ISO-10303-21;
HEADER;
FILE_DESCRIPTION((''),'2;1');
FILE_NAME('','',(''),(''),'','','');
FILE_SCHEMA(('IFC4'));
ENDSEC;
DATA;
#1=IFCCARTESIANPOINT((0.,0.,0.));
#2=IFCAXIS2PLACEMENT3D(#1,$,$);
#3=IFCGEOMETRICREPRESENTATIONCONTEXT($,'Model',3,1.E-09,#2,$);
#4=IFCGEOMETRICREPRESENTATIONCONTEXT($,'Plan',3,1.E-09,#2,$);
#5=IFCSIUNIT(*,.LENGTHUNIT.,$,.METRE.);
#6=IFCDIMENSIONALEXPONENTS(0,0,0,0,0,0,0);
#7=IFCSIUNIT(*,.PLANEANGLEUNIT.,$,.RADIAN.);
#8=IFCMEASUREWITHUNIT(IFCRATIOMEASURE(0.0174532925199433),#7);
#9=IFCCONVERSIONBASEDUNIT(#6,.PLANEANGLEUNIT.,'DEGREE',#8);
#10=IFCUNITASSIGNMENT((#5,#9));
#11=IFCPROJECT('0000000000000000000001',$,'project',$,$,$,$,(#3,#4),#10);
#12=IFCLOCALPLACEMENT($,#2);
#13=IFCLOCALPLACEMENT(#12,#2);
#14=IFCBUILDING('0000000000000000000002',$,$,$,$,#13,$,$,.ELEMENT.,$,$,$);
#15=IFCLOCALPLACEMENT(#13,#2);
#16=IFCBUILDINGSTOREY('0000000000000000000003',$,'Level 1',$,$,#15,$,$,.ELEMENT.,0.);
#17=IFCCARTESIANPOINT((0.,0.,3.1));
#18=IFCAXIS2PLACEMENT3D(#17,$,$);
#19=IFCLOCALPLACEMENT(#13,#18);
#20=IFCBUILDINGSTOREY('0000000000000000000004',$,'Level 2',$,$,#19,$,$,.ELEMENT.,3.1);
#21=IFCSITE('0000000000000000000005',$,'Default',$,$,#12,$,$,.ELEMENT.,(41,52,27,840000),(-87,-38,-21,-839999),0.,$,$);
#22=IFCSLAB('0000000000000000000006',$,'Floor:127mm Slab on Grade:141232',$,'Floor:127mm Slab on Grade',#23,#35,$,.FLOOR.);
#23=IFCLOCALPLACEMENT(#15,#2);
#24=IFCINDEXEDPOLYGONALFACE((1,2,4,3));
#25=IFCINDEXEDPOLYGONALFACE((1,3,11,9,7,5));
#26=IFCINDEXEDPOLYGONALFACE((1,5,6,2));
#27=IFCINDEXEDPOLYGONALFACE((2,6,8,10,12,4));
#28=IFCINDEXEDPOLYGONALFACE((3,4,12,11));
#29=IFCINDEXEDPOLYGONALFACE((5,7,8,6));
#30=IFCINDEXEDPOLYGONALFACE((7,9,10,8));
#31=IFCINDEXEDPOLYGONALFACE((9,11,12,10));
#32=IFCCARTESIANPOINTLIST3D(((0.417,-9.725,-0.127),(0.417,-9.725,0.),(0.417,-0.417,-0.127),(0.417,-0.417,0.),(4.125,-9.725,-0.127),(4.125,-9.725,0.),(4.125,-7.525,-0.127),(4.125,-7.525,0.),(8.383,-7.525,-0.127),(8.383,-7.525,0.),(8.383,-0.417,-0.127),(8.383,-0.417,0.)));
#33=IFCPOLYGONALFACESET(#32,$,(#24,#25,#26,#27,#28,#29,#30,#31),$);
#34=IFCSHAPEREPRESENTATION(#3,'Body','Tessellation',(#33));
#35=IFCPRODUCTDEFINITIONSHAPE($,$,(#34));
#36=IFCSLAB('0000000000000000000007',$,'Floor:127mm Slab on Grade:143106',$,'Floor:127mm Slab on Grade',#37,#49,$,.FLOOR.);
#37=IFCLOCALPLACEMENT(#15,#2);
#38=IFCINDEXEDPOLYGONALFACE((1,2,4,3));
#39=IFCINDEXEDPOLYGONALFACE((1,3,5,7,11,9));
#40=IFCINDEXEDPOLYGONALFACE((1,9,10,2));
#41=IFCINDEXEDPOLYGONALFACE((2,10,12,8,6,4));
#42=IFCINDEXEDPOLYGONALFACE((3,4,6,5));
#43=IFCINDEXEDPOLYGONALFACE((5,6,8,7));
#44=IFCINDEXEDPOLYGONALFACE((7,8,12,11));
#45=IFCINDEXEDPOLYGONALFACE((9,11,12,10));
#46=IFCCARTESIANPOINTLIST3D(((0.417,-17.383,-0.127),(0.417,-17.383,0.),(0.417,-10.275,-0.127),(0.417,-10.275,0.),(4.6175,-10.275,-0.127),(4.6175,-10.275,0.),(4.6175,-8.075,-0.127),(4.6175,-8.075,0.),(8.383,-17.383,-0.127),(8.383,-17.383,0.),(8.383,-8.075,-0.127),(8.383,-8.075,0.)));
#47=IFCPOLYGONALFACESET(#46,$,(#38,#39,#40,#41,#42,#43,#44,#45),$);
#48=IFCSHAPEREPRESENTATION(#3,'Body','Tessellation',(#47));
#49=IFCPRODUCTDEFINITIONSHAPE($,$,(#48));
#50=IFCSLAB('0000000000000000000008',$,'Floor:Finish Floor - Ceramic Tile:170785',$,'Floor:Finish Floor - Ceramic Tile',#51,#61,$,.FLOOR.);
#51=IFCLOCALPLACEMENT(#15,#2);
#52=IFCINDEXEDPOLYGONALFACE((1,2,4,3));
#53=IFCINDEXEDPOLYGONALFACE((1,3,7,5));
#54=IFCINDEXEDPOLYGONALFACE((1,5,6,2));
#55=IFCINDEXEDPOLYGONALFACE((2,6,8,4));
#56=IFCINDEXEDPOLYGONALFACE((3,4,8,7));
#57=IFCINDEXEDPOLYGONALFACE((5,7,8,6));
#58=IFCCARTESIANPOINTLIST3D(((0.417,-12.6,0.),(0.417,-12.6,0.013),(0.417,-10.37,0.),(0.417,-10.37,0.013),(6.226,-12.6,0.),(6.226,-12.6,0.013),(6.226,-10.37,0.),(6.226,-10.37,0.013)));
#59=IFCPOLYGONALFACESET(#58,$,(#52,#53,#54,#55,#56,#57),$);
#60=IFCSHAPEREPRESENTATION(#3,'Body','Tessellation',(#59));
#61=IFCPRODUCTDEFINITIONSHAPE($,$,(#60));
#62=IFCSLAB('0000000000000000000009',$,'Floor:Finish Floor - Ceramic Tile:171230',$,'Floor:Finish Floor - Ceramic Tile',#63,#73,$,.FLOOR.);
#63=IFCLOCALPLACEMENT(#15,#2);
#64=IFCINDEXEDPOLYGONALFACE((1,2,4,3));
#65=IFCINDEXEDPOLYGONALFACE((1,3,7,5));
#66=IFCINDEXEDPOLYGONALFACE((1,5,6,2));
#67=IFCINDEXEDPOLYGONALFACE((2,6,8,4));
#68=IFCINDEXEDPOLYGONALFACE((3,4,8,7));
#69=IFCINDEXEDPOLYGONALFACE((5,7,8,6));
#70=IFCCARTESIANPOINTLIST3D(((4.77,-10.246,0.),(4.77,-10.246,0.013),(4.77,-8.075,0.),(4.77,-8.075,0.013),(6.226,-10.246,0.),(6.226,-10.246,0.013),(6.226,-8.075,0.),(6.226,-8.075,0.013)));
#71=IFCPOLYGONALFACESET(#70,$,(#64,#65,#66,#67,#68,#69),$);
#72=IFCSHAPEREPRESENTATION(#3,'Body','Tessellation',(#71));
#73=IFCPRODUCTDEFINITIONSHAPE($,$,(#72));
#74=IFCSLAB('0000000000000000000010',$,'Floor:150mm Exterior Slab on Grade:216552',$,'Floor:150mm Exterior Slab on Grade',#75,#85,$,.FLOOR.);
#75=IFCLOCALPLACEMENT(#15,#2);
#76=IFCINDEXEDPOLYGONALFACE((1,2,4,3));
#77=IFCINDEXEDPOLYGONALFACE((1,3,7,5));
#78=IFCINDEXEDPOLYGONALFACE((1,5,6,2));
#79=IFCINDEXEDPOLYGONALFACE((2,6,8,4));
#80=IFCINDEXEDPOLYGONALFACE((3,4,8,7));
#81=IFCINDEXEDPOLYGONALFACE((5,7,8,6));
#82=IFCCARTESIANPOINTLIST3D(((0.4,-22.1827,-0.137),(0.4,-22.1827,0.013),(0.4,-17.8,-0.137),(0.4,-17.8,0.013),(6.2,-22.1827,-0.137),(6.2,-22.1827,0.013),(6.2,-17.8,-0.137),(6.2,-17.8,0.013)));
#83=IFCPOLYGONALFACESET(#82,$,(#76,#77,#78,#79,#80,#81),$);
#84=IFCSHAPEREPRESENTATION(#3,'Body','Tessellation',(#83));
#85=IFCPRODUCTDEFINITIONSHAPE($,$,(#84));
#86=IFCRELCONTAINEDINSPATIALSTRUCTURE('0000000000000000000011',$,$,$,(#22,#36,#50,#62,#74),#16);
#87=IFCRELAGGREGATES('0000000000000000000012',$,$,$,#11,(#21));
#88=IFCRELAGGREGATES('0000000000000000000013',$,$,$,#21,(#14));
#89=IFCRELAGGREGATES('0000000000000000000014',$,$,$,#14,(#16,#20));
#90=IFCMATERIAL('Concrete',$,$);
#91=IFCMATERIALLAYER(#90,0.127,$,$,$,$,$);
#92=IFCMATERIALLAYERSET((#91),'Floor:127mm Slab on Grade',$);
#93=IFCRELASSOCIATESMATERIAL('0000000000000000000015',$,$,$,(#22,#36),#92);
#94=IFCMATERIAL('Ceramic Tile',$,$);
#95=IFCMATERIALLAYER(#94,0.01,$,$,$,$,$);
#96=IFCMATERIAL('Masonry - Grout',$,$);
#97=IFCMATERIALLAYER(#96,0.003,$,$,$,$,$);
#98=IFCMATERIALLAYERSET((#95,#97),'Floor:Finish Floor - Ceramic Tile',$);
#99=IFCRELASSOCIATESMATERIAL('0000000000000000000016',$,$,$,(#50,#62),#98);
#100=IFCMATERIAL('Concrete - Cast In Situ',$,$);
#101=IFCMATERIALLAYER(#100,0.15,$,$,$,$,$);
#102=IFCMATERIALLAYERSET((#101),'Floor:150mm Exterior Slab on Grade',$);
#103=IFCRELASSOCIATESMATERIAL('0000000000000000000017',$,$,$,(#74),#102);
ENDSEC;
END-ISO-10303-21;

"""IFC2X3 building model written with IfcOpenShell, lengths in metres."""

from ifc_helpers import new_model, entity, si_unit, converted_unit, frame, frame_2d, origin, origin_2d_with_axis, place, context, project, spatial, polyline, rectangle, outline, extrude, material, layer, layer_set, layer_usage, element, save


model = new_model("IFC2X3")

# Units and contexts
model_context = context("Model", 3, precision=1e-09, world=origin())
plan_context = context("Plan", 3, precision=1e-09, world=origin())
ifc_project = project(units=[si_unit("LENGTHUNIT", "METRE"), converted_unit("PLANEANGLEUNIT", "DEGREE", entity("IfcRatioMeasure", 0.0174532925199433), si_unit("PLANEANGLEUNIT", "RADIAN"), dimensions=[0, 0, 0, 0, 0, 0, 0])], contexts=[model_context, plan_context])

# Site, building, storey
site_placement = place(None, origin())
site = spatial("IfcSite", under=ifc_project, at=site_placement, Name="Default", CompositionType="ELEMENT", RefLatitude=(41, 52, 27, 840000), RefLongitude=(-87, -38, -21, -839999), RefElevation=0.0)
building_placement = place(site_placement, origin())
building = spatial("IfcBuilding", under=site, at=building_placement, CompositionType="ELEMENT")
storey_1_placement = place(building_placement, origin())
storey_1 = spatial("IfcBuildingStorey", under=building, at=storey_1_placement, Name="Level 1", CompositionType="ELEMENT", Elevation=0.0)

# Slabs
ifc_material_1 = material(Name="Concrete")
ifc_layer_1 = layer(ifc_material_1, 0.127)
ifc_layer_set_1 = layer_set([ifc_layer_1], Name="Floor:127mm Slab on Grade")
ifc_layer_usage_1 = layer_usage(ifc_layer_set_1, "AXIS3", "POSITIVE", 0.0)
slab_1_placement = place(storey_1_placement, frame((0.417, -9.725, -0.127)))
element("IfcSlab", 1, at=slab_1_placement, inside=storey_1, material=ifc_layer_usage_1, Name="Floor:127mm Slab on Grade:141232", ObjectType="Floor:127mm Slab on Grade", PredefinedType="FLOOR", context=model_context, shape_type="SweptSolid", body=[
    extrude(outline(polyline([(-3.983, 4.654), (-3.983, -2.454), (0.275, -2.454), (0.275, -4.654), (3.983, -4.654), (3.983, 4.654), (-3.983, 4.654)])), frame((3.983, 4.654, 0.127), z_axis=(0.0, 0.0, -1.0), x_axis=(-1.0, 0.0, 0.0)), (0.0, 0.0, 1.0), 0.127),
])
ifc_layer_usage_2 = layer_usage(ifc_layer_set_1, "AXIS3", "POSITIVE", 0.0)
slab_2_placement = place(storey_1_placement, frame((0.417, -17.383, -0.127)))
element("IfcSlab", 2, at=slab_2_placement, inside=storey_1, material=ifc_layer_usage_2, Name="Floor:127mm Slab on Grade:143106", ObjectType="Floor:127mm Slab on Grade", PredefinedType="FLOOR", context=model_context, shape_type="SweptSolid", body=[
    extrude(outline(polyline([(-3.983, 4.654), (-3.983, -4.654), (3.983, -4.654), (3.983, 2.454), (-0.2175, 2.454), (-0.2175, 4.654), (-3.983, 4.654)])), frame((3.983, 4.654, 0.127), z_axis=(0.0, 0.0, -1.0), x_axis=(-1.0, 0.0, 0.0)), (0.0, 0.0, 1.0), 0.127),
])
ifc_material_2 = material(Name="Ceramic Tile")
ifc_layer_2 = layer(ifc_material_2, 0.01)
ifc_material_3 = material(Name="Masonry - Grout")
ifc_layer_3 = layer(ifc_material_3, 0.003)
ifc_layer_set_2 = layer_set([ifc_layer_2, ifc_layer_3], Name="Floor:Finish Floor - Ceramic Tile")
ifc_layer_usage_3 = layer_usage(ifc_layer_set_2, "AXIS3", "POSITIVE", 0.0)
slab_3_placement = place(storey_1_placement, frame((0.417, -12.6, 0.0)))
element("IfcSlab", 3, at=slab_3_placement, inside=storey_1, material=ifc_layer_usage_3, Name="Floor:Finish Floor - Ceramic Tile:170785", ObjectType="Floor:Finish Floor - Ceramic Tile", PredefinedType="FLOOR", context=model_context, shape_type="SweptSolid", body=[
    extrude(rectangle(XDim=5.809, YDim=2.23, at=frame_2d((0.0, 0.0), x_axis=(-1.0, 0.0))), frame((2.9045, 1.115, 0.013), z_axis=(0.0, 0.0, -1.0), x_axis=(-1.0, 0.0, 0.0)), (0.0, 0.0, 1.0), 0.013),
])
ifc_layer_usage_4 = layer_usage(ifc_layer_set_2, "AXIS3", "POSITIVE", 0.0)
slab_4_placement = place(storey_1_placement, frame((4.77, -10.246, 0.0)))
element("IfcSlab", 4, at=slab_4_placement, inside=storey_1, material=ifc_layer_usage_4, Name="Floor:Finish Floor - Ceramic Tile:171230", ObjectType="Floor:Finish Floor - Ceramic Tile", PredefinedType="FLOOR", context=model_context, shape_type="SweptSolid", body=[
    extrude(rectangle(XDim=1.456, YDim=2.171, at=frame_2d((0.0, 0.0), x_axis=(-1.0, 0.0))), frame((0.728, 1.0855, 0.013), z_axis=(0.0, 0.0, -1.0), x_axis=(-1.0, 0.0, 0.0)), (0.0, 0.0, 1.0), 0.013),
])
ifc_material_4 = material(Name="Concrete - Cast In Situ")
ifc_layer_4 = layer(ifc_material_4, 0.15)
ifc_layer_set_3 = layer_set([ifc_layer_4], Name="Floor:150mm Exterior Slab on Grade")
ifc_layer_usage_5 = layer_usage(ifc_layer_set_3, "AXIS3", "POSITIVE", 0.0)
slab_5_placement = place(storey_1_placement, frame((0.4, -22.1827, -0.137)))
element("IfcSlab", 5, at=slab_5_placement, inside=storey_1, material=ifc_layer_usage_5, Name="Floor:150mm Exterior Slab on Grade:216552", ObjectType="Floor:150mm Exterior Slab on Grade", PredefinedType="FLOOR", context=model_context, shape_type="SweptSolid", body=[
    extrude(rectangle(XDim=5.8, YDim=4.3827, at=origin_2d_with_axis()), frame((2.9, 2.1914, 0.15), z_axis=(0.0, 0.0, -1.0), x_axis=(-1.0, 0.0, 0.0)), (0.0, 0.0, 1.0), 0.15),
])

# Shared definitions
storey_2_placement = place(building_placement, frame((0.0, 0.0, 3.1)))
storey_2 = spatial("IfcBuildingStorey", under=building, at=storey_2_placement, Name="Level 2", CompositionType="ELEMENT", Elevation=3.1)

save(model, "model.ifc")
